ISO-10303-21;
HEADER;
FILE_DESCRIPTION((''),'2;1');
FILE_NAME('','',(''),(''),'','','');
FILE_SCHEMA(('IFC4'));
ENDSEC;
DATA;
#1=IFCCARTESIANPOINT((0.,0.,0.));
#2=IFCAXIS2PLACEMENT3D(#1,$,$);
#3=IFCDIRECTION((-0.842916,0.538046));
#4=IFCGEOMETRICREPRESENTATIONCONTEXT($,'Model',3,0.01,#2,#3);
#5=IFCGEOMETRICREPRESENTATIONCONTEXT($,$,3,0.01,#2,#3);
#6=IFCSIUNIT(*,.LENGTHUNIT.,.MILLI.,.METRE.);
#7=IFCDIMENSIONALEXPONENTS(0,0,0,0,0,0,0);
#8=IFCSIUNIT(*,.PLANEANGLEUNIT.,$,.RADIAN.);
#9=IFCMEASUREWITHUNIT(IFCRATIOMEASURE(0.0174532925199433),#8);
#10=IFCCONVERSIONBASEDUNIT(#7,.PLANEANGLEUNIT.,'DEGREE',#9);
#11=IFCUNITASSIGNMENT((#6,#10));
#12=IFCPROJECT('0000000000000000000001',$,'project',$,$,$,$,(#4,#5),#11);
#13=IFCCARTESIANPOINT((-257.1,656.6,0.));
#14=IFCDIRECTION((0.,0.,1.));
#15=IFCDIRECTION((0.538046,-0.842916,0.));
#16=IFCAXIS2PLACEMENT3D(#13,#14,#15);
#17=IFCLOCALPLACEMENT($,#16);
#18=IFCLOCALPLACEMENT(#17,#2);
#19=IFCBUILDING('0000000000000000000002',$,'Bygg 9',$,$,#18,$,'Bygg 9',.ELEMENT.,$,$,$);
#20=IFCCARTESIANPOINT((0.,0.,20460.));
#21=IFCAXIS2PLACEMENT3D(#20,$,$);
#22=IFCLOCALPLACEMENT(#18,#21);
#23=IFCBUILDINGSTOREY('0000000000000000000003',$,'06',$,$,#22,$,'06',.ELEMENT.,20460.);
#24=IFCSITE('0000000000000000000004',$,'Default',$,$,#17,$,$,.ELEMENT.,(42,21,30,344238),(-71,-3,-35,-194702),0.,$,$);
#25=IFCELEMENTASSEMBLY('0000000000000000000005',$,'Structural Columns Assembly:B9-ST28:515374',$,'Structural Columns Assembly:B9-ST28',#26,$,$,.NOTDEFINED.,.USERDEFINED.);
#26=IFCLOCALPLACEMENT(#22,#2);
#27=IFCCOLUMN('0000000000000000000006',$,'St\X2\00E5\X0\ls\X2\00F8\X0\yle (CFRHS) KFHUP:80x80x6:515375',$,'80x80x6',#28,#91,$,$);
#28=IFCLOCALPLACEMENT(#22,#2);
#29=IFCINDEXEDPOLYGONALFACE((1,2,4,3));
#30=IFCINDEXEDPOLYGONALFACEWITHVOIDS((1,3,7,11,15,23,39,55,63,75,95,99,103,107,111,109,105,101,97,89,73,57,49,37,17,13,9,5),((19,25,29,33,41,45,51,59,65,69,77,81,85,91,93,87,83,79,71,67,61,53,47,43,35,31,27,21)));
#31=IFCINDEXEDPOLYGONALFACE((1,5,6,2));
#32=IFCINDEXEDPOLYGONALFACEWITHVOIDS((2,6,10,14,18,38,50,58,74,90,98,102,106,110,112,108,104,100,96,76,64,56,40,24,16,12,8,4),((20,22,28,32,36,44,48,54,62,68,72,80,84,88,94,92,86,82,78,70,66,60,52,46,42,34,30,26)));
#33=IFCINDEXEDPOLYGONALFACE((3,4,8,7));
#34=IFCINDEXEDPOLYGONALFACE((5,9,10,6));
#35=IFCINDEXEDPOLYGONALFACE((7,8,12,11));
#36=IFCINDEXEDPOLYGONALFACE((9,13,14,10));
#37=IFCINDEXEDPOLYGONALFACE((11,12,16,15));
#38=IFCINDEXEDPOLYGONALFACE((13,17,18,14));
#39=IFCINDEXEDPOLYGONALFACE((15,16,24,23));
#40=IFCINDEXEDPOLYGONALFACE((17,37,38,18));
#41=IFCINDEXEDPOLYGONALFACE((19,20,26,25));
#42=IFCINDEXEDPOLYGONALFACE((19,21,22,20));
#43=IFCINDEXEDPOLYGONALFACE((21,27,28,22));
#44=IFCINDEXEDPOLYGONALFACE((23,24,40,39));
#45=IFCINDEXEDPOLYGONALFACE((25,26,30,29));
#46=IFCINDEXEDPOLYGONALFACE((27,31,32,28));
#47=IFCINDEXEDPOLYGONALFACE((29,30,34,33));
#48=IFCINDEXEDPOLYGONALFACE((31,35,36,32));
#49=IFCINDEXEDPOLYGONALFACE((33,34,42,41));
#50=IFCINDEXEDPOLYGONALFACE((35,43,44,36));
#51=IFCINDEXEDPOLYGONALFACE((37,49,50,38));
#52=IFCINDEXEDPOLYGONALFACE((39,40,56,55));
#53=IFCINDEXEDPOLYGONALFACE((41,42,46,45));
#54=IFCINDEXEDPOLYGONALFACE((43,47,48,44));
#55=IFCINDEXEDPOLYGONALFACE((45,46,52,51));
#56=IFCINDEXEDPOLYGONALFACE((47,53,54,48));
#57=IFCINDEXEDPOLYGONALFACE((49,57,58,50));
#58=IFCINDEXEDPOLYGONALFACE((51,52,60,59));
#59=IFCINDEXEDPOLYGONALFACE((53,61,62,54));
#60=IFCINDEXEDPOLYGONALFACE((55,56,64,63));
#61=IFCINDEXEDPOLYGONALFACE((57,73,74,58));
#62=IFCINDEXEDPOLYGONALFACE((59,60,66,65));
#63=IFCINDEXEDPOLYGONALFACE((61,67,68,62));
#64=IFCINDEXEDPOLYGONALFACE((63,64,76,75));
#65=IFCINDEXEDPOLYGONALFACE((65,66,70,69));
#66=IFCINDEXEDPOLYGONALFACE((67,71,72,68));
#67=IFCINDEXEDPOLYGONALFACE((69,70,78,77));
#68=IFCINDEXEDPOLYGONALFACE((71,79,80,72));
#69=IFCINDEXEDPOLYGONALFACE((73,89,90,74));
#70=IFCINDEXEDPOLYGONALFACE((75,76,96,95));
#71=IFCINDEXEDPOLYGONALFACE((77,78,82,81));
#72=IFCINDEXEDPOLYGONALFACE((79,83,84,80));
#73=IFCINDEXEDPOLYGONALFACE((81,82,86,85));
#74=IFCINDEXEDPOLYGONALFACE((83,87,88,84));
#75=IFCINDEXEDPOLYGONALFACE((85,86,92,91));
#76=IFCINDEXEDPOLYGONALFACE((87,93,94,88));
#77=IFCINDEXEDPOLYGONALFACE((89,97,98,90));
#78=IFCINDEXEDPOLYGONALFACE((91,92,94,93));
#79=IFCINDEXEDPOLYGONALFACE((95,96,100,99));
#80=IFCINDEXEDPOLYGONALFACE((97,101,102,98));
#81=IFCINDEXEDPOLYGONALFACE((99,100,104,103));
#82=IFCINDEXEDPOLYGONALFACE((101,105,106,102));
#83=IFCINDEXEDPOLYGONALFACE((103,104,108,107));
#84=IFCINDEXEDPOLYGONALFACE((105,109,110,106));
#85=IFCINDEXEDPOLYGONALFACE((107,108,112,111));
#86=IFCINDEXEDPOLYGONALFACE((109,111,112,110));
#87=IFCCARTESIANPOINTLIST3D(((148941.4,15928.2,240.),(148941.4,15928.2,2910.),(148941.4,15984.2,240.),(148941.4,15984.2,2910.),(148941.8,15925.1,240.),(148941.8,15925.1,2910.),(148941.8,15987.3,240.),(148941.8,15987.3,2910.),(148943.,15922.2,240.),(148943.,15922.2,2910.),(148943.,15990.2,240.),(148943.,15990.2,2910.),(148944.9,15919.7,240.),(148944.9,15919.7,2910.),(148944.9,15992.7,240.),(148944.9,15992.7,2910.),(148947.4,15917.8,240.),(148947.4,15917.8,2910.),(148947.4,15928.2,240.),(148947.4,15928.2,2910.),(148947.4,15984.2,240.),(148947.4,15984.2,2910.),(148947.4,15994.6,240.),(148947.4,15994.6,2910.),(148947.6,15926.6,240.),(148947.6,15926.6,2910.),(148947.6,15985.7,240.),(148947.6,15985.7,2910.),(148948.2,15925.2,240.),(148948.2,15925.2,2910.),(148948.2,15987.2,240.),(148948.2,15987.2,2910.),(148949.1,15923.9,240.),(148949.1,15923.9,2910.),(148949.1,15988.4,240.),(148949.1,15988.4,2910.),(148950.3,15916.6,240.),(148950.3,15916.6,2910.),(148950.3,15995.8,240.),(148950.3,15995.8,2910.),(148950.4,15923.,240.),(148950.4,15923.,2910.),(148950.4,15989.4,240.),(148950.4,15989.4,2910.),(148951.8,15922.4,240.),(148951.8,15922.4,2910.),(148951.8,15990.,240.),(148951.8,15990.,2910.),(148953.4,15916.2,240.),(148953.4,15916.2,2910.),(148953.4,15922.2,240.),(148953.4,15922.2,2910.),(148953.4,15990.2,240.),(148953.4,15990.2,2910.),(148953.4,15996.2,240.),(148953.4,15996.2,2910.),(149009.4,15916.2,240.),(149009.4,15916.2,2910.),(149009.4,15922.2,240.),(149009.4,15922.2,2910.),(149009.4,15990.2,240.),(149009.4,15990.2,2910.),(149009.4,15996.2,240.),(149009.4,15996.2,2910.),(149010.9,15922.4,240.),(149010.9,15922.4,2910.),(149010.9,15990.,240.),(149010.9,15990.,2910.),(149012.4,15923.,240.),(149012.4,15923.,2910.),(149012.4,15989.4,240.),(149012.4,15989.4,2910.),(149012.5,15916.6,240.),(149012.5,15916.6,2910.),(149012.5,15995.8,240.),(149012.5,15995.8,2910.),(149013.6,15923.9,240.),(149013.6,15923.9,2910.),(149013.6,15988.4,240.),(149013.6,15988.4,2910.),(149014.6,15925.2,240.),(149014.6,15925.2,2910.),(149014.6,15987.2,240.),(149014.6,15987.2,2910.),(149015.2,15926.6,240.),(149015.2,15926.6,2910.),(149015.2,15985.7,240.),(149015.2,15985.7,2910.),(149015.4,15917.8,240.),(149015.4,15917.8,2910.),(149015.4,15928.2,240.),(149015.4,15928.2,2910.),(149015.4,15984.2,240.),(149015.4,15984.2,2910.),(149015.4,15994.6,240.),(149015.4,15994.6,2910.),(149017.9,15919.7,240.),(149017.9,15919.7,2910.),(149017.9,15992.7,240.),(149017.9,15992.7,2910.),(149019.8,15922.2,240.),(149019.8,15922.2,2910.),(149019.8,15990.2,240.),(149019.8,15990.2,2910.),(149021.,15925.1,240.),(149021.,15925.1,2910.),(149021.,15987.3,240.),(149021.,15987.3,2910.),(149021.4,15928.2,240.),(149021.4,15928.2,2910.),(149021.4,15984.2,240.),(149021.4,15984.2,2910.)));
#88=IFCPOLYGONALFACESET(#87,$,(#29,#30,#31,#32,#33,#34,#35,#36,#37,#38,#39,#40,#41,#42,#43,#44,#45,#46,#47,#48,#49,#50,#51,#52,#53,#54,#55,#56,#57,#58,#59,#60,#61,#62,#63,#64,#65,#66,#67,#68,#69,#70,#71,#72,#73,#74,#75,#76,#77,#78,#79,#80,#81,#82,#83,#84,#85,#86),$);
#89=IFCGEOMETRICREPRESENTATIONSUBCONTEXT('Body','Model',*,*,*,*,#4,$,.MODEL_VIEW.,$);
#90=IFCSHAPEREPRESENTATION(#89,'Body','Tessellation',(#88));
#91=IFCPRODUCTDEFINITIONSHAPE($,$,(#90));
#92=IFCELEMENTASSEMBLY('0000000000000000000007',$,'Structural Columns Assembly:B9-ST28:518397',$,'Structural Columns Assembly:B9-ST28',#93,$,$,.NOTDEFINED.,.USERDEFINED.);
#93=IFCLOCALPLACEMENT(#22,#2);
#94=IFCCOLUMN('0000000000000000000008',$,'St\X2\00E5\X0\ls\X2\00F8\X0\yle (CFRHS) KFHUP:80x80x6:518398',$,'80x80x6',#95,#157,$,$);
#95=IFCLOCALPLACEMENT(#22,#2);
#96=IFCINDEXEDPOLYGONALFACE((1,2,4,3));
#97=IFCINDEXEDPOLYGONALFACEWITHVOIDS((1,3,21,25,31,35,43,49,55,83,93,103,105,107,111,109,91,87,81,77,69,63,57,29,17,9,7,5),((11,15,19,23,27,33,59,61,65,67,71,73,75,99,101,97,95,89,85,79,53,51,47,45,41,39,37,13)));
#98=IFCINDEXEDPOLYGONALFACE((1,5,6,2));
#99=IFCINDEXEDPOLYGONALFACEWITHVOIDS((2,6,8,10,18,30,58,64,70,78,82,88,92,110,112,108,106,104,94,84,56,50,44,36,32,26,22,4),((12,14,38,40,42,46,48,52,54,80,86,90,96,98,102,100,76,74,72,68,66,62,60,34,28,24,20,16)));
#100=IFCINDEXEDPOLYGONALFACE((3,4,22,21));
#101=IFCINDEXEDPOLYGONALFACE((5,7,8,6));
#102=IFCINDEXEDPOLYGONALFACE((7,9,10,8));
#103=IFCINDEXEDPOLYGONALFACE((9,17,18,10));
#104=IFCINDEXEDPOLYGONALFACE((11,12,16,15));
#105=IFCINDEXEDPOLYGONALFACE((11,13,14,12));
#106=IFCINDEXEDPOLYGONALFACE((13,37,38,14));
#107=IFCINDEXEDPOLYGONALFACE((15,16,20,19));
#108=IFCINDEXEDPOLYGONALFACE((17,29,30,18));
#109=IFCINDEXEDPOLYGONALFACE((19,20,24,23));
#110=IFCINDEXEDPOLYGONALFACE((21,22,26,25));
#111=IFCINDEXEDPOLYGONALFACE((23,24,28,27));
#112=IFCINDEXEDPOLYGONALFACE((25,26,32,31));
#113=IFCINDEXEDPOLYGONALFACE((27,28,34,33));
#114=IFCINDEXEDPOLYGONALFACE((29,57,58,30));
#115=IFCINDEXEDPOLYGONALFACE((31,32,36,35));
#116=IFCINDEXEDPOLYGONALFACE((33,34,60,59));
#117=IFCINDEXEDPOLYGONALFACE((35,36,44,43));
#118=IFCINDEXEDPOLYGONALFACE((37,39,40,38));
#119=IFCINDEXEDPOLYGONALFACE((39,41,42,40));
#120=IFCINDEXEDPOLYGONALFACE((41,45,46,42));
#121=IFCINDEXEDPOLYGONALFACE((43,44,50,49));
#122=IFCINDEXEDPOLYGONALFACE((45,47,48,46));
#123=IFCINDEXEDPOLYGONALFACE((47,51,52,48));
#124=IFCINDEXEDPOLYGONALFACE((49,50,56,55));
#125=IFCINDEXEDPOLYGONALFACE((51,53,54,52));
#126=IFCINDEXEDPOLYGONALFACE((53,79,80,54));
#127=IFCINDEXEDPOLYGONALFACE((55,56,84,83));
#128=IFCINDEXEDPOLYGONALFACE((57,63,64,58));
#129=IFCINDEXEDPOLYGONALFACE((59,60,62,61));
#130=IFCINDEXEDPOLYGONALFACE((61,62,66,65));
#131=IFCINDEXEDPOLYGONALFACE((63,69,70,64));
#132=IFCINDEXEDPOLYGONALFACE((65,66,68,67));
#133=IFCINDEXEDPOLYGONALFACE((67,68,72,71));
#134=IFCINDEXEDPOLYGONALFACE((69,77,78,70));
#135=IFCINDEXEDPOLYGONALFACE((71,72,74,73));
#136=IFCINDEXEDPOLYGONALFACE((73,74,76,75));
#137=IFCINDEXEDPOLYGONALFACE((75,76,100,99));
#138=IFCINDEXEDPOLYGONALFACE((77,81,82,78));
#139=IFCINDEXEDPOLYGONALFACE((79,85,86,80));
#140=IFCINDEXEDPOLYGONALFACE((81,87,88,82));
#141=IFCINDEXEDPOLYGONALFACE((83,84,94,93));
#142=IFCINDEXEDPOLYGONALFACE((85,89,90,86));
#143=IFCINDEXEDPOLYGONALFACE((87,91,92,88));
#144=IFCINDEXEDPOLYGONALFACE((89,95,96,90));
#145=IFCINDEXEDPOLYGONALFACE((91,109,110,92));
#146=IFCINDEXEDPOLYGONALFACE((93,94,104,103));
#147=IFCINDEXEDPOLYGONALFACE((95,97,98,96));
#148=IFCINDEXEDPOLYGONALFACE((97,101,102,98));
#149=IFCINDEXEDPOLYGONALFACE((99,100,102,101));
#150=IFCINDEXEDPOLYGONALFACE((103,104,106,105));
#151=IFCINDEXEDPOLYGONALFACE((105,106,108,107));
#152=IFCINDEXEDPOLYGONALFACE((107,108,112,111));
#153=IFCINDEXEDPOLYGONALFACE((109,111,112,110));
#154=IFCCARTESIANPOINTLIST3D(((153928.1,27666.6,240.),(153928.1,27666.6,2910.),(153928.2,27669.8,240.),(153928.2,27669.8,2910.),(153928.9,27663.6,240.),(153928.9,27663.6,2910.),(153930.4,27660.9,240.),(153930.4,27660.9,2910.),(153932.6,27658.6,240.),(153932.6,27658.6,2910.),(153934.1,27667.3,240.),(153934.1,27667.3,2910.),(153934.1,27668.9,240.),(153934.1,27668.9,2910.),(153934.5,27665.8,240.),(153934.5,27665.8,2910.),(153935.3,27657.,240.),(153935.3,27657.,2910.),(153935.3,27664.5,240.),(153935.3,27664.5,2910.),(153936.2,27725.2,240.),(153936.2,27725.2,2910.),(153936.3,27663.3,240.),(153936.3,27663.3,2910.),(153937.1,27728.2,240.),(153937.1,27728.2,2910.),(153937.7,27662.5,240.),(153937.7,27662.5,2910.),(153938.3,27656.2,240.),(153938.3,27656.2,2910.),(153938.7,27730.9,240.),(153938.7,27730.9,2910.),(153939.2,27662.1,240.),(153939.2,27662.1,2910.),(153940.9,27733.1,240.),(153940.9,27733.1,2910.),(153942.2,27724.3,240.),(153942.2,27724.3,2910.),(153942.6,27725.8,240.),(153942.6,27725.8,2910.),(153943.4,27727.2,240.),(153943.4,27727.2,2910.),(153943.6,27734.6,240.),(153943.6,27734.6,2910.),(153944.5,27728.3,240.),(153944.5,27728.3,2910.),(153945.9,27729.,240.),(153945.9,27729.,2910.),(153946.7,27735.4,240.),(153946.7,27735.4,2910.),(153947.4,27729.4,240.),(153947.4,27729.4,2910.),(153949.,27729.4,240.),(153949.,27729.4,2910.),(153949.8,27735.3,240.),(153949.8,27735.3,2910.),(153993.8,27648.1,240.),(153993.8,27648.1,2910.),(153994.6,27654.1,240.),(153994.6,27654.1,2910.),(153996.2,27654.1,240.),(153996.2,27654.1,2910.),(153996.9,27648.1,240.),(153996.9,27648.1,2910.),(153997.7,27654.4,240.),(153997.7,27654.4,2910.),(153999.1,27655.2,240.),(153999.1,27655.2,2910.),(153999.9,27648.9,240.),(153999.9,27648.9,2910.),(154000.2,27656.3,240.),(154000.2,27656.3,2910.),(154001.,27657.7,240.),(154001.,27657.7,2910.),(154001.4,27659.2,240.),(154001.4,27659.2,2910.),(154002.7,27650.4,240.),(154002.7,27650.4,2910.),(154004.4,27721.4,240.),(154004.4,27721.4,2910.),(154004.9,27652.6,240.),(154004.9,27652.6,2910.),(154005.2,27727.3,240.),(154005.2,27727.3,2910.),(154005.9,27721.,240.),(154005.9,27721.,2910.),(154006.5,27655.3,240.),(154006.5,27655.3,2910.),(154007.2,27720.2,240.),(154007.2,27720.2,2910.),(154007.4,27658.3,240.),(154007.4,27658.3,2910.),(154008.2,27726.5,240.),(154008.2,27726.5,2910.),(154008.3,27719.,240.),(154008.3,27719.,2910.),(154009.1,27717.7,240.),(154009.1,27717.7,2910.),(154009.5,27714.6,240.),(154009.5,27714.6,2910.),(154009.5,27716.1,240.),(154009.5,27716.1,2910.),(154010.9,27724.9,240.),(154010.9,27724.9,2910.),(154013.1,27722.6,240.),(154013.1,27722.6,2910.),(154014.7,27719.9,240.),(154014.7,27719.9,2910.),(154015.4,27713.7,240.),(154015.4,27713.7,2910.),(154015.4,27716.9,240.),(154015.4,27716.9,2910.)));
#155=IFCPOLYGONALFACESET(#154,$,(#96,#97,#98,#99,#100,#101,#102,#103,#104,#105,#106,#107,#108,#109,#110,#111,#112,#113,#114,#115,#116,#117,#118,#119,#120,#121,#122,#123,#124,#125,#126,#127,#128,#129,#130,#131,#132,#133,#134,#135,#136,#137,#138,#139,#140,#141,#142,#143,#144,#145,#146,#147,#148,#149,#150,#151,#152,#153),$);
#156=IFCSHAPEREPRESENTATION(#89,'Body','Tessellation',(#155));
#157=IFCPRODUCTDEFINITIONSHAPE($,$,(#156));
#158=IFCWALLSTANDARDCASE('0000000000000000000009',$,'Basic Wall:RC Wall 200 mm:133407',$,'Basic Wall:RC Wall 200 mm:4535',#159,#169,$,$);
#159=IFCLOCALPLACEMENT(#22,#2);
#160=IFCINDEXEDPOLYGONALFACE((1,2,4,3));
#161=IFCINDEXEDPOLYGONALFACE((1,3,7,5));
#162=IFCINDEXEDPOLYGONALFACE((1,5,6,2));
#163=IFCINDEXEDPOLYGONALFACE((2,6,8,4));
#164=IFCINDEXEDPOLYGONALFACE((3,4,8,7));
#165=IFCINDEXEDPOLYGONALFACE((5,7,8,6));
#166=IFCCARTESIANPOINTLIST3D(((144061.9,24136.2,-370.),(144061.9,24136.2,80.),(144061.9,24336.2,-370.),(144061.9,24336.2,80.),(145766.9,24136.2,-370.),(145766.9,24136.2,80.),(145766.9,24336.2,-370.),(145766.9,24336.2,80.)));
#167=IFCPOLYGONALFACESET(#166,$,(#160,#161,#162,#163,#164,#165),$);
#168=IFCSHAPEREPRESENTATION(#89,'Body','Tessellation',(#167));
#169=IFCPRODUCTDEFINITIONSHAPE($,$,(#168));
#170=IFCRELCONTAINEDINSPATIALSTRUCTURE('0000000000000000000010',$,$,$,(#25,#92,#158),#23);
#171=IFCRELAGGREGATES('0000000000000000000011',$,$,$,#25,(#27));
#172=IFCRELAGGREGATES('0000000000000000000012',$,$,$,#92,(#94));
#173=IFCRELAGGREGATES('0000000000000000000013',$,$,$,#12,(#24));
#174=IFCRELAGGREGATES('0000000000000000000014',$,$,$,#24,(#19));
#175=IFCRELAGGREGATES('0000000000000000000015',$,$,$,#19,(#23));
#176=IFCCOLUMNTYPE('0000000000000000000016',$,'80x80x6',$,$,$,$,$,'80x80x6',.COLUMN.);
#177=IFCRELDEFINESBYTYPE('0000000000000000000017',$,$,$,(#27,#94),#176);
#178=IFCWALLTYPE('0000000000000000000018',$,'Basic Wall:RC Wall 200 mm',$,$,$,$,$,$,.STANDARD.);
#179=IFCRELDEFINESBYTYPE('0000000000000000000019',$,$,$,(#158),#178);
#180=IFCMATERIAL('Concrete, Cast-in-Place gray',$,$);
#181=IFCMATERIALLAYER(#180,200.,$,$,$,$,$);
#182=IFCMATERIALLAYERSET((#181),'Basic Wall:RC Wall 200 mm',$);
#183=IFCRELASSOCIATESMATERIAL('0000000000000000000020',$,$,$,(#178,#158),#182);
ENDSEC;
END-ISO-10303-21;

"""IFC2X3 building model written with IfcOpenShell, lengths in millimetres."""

from ifc_helpers import new_model, entity, si_unit, converted_unit, direction, frame, frame_2d, origin, place, context, subcontext, project, spatial, polyline, circle_curve, parameter, trimmed, segment, composite_curve, rectangle, outline, extrude, source, transform, mapped, material, layer, layer_set, layer_usage, type_object, type_shapes, element, aggregate, save


model = new_model("IFC2X3")

# Units and contexts
model_context = context("Model", 3, precision=0.01, world=origin(), true_north=direction((-0.842916, 0.538046)))
context_of_model = context(None, 3, precision=0.01, world=origin(), true_north=direction((-0.842916, 0.538046)))
body_context = subcontext(model_context, "Body", "Model", "MODEL_VIEW")
ifc_project = project(units=[si_unit("LENGTHUNIT", "METRE", prefix="MILLI"), converted_unit("PLANEANGLEUNIT", "DEGREE", entity("IfcRatioMeasure", 0.0174532925199433), si_unit("PLANEANGLEUNIT", "RADIAN"), dimensions=[0, 0, 0, 0, 0, 0, 0])], contexts=[model_context, context_of_model])

# Site, building, storey
site_placement = place(None, frame((-257.1, 656.6, 0.0), z_axis=(0.0, 0.0, 1.0), x_axis=(0.538046, -0.842916, 0.0)))
site = spatial("IfcSite", under=ifc_project, at=site_placement, Name="Default", CompositionType="ELEMENT", RefLatitude=(42, 21, 30, 344238), RefLongitude=(-71, -3, -35, -194702), RefElevation=0.0)
building_placement = place(site_placement, origin())
building = spatial("IfcBuilding", under=site, at=building_placement, Name="Bygg 9", LongName="Bygg 9", CompositionType="ELEMENT")
storey_placement = place(building_placement, frame((0.0, 0.0, 20460.0)))
storey = spatial("IfcBuildingStorey", under=building, at=storey_placement, Name="06", LongName="06", CompositionType="ELEMENT", Elevation=20460.0)

# Element assemblies, columns
column_type = type_object("IfcColumnType", Name="80x80x6", ElementType="80x80x6", PredefinedType="COLUMN")
shared_shape_1 = source(origin(), body_context, "Body", "SweptSolid", [
    extrude(outline(composite_curve([segment(trimmed(circle_curve(frame_2d((-28.0, 28.0), x_axis=(1.0, 0.0)), 12.0), [parameter(90.0)], [parameter(180.0)], True, "PARAMETER"), True, "CONTINUOUS"), segment(polyline([(-40.0, 28.0), (-40.0, -28.0)]), True, "CONTINUOUS"), segment(trimmed(circle_curve(frame_2d((-28.0, -28.0), x_axis=(1.0, 0.0)), 12.0), [parameter(180.0)], [parameter(270.0)], True, "PARAMETER"), True, "CONTINUOUS"), segment(polyline([(-28.0, -40.0), (28.0, -40.0)]), True, "CONTINUOUS"), segment(trimmed(circle_curve(frame_2d((28.0, -28.0), x_axis=(1.0, 0.0)), 12.0), [parameter(270.0)], [parameter(0.0)], True, "PARAMETER"), True, "CONTINUOUS"), segment(polyline([(40.0, -28.0), (40.0, 28.0)]), True, "CONTINUOUS"), segment(trimmed(circle_curve(frame_2d((28.0, 28.0), x_axis=(1.0, 0.0)), 12.0), [parameter(0.0)], [parameter(90.0)], True, "PARAMETER"), True, "CONTINUOUS"), segment(polyline([(28.0, 40.0), (-28.0, 40.0)]), True, "CONTINUOUS")], self_intersect=False), holes=[composite_curve([segment(polyline([(-28.0, 34.0), (28.0, 34.0)]), True, "CONTINUOUS"), segment(trimmed(circle_curve(frame_2d((28.0, 28.0), x_axis=(1.0, 0.0)), 6.0), [parameter(360.0)], [parameter(90.0)], True, "PARAMETER"), False, "CONTINUOUS"), segment(polyline([(34.0, 28.0), (34.0, -28.0)]), True, "CONTINUOUS"), segment(trimmed(circle_curve(frame_2d((28.0, -28.0), x_axis=(1.0, 0.0)), 6.0), [parameter(270.0)], [parameter(360.0)], True, "PARAMETER"), False, "CONTINUOUS"), segment(polyline([(28.0, -34.0), (-28.0, -34.0)]), True, "CONTINUOUS"), segment(trimmed(circle_curve(frame_2d((-28.0, -28.0), x_axis=(1.0, 0.0)), 6.0), [parameter(180.0)], [parameter(270.0)], True, "PARAMETER"), False, "CONTINUOUS"), segment(polyline([(-34.0, -28.0), (-34.0, 28.0)]), True, "CONTINUOUS"), segment(trimmed(circle_curve(frame_2d((-28.0, 28.0), x_axis=(1.0, 0.0)), 6.0), [parameter(90.0)], [parameter(180.0)], True, "PARAMETER"), False, "CONTINUOUS")], self_intersect=False)]), frame((41.6, 41.6, 0.0), z_axis=(0.0, 0.0, 1.0), x_axis=(-1.0, 0.0, 0.0)), (0.0, 0.0, 1.0), 2670.0),
])
type_shapes(column_type, [shared_shape_1])
assembly_1_placement = place(storey_placement, origin())
assembly_1 = element("IfcElementAssembly", 1, at=assembly_1_placement, inside=storey, Name="Structural Columns Assembly:B9-ST28:515374", ObjectType="Structural Columns Assembly:B9-ST28", AssemblyPlace="NOTDEFINED", PredefinedType="USERDEFINED")
column_1_placement = place(assembly_1_placement, frame((149023.0, 15914.6, 240.0), z_axis=(0.0, 0.0, 1.0), x_axis=(0.0, 1.0, 0.0)))
column_1 = element("IfcColumn", 2, at=column_1_placement, type_object=column_type, Name="Stålsøyle (CFRHS) KFHUP:80x80x6:515375", ObjectType="80x80x6", context=body_context, shape_type="MappedRepresentation", body=[
    mapped(shared_shape_1, transform((0.0, 0.0, 0.0), scale=1.0)),
])
assembly_2_placement = place(storey_placement, origin())
assembly_2 = element("IfcElementAssembly", 3, at=assembly_2_placement, inside=storey, Name="Structural Columns Assembly:B9-ST28:518397", ObjectType="Structural Columns Assembly:B9-ST28", AssemblyPlace="NOTDEFINED", PredefinedType="USERDEFINED")
column_2_placement = place(assembly_2_placement, frame((154018.9, 27726.9, 240.0), z_axis=(0.0, 0.0, 1.0), x_axis=(-0.989663, 0.143415, 0.0)))
column_2 = element("IfcColumn", 4, at=column_2_placement, type_object=column_type, Name="Stålsøyle (CFRHS) KFHUP:80x80x6:518398", ObjectType="80x80x6", context=body_context, shape_type="MappedRepresentation", body=[
    mapped(shared_shape_1, transform((0.0, 0.0, 0.0), scale=1.0)),
])

# Shared definitions
ifc_material_1 = material(Name="Concrete, Cast-in-Place gray")

# Wall
ifc_layer_1 = layer(ifc_material_1, 200.0)
ifc_layer_set_1 = layer_set([ifc_layer_1], Name="Basic Wall:RC Wall 200 mm")
ifc_layer_usage_1 = layer_usage(ifc_layer_set_1, "AXIS2", "NEGATIVE", 100.0)
wall_type = type_object("IfcWallType", Name="Basic Wall:RC Wall 200 mm", PredefinedType="STANDARD", material=ifc_layer_set_1)
wall_1_placement = place(storey_placement, frame((144061.9, 24236.2, -370.0)))
element("IfcWallStandardCase", 5, at=wall_1_placement, inside=storey, type_object=wall_type, material=ifc_layer_usage_1, Name="Basic Wall:RC Wall 200 mm:133407", ObjectType="Basic Wall:RC Wall 200 mm:4535", context=body_context, shape_type="SweptSolid", body=[
    extrude(rectangle(XDim=1705.0, YDim=200.0, at=frame_2d((852.5, 0.0), x_axis=(-1.0, 0.0))), origin(), (0.0, 0.0, 1.0), 450.0),
])

aggregate(assembly_1, [column_1])
aggregate(assembly_2, [column_2])

save(model, "model.ifc")
